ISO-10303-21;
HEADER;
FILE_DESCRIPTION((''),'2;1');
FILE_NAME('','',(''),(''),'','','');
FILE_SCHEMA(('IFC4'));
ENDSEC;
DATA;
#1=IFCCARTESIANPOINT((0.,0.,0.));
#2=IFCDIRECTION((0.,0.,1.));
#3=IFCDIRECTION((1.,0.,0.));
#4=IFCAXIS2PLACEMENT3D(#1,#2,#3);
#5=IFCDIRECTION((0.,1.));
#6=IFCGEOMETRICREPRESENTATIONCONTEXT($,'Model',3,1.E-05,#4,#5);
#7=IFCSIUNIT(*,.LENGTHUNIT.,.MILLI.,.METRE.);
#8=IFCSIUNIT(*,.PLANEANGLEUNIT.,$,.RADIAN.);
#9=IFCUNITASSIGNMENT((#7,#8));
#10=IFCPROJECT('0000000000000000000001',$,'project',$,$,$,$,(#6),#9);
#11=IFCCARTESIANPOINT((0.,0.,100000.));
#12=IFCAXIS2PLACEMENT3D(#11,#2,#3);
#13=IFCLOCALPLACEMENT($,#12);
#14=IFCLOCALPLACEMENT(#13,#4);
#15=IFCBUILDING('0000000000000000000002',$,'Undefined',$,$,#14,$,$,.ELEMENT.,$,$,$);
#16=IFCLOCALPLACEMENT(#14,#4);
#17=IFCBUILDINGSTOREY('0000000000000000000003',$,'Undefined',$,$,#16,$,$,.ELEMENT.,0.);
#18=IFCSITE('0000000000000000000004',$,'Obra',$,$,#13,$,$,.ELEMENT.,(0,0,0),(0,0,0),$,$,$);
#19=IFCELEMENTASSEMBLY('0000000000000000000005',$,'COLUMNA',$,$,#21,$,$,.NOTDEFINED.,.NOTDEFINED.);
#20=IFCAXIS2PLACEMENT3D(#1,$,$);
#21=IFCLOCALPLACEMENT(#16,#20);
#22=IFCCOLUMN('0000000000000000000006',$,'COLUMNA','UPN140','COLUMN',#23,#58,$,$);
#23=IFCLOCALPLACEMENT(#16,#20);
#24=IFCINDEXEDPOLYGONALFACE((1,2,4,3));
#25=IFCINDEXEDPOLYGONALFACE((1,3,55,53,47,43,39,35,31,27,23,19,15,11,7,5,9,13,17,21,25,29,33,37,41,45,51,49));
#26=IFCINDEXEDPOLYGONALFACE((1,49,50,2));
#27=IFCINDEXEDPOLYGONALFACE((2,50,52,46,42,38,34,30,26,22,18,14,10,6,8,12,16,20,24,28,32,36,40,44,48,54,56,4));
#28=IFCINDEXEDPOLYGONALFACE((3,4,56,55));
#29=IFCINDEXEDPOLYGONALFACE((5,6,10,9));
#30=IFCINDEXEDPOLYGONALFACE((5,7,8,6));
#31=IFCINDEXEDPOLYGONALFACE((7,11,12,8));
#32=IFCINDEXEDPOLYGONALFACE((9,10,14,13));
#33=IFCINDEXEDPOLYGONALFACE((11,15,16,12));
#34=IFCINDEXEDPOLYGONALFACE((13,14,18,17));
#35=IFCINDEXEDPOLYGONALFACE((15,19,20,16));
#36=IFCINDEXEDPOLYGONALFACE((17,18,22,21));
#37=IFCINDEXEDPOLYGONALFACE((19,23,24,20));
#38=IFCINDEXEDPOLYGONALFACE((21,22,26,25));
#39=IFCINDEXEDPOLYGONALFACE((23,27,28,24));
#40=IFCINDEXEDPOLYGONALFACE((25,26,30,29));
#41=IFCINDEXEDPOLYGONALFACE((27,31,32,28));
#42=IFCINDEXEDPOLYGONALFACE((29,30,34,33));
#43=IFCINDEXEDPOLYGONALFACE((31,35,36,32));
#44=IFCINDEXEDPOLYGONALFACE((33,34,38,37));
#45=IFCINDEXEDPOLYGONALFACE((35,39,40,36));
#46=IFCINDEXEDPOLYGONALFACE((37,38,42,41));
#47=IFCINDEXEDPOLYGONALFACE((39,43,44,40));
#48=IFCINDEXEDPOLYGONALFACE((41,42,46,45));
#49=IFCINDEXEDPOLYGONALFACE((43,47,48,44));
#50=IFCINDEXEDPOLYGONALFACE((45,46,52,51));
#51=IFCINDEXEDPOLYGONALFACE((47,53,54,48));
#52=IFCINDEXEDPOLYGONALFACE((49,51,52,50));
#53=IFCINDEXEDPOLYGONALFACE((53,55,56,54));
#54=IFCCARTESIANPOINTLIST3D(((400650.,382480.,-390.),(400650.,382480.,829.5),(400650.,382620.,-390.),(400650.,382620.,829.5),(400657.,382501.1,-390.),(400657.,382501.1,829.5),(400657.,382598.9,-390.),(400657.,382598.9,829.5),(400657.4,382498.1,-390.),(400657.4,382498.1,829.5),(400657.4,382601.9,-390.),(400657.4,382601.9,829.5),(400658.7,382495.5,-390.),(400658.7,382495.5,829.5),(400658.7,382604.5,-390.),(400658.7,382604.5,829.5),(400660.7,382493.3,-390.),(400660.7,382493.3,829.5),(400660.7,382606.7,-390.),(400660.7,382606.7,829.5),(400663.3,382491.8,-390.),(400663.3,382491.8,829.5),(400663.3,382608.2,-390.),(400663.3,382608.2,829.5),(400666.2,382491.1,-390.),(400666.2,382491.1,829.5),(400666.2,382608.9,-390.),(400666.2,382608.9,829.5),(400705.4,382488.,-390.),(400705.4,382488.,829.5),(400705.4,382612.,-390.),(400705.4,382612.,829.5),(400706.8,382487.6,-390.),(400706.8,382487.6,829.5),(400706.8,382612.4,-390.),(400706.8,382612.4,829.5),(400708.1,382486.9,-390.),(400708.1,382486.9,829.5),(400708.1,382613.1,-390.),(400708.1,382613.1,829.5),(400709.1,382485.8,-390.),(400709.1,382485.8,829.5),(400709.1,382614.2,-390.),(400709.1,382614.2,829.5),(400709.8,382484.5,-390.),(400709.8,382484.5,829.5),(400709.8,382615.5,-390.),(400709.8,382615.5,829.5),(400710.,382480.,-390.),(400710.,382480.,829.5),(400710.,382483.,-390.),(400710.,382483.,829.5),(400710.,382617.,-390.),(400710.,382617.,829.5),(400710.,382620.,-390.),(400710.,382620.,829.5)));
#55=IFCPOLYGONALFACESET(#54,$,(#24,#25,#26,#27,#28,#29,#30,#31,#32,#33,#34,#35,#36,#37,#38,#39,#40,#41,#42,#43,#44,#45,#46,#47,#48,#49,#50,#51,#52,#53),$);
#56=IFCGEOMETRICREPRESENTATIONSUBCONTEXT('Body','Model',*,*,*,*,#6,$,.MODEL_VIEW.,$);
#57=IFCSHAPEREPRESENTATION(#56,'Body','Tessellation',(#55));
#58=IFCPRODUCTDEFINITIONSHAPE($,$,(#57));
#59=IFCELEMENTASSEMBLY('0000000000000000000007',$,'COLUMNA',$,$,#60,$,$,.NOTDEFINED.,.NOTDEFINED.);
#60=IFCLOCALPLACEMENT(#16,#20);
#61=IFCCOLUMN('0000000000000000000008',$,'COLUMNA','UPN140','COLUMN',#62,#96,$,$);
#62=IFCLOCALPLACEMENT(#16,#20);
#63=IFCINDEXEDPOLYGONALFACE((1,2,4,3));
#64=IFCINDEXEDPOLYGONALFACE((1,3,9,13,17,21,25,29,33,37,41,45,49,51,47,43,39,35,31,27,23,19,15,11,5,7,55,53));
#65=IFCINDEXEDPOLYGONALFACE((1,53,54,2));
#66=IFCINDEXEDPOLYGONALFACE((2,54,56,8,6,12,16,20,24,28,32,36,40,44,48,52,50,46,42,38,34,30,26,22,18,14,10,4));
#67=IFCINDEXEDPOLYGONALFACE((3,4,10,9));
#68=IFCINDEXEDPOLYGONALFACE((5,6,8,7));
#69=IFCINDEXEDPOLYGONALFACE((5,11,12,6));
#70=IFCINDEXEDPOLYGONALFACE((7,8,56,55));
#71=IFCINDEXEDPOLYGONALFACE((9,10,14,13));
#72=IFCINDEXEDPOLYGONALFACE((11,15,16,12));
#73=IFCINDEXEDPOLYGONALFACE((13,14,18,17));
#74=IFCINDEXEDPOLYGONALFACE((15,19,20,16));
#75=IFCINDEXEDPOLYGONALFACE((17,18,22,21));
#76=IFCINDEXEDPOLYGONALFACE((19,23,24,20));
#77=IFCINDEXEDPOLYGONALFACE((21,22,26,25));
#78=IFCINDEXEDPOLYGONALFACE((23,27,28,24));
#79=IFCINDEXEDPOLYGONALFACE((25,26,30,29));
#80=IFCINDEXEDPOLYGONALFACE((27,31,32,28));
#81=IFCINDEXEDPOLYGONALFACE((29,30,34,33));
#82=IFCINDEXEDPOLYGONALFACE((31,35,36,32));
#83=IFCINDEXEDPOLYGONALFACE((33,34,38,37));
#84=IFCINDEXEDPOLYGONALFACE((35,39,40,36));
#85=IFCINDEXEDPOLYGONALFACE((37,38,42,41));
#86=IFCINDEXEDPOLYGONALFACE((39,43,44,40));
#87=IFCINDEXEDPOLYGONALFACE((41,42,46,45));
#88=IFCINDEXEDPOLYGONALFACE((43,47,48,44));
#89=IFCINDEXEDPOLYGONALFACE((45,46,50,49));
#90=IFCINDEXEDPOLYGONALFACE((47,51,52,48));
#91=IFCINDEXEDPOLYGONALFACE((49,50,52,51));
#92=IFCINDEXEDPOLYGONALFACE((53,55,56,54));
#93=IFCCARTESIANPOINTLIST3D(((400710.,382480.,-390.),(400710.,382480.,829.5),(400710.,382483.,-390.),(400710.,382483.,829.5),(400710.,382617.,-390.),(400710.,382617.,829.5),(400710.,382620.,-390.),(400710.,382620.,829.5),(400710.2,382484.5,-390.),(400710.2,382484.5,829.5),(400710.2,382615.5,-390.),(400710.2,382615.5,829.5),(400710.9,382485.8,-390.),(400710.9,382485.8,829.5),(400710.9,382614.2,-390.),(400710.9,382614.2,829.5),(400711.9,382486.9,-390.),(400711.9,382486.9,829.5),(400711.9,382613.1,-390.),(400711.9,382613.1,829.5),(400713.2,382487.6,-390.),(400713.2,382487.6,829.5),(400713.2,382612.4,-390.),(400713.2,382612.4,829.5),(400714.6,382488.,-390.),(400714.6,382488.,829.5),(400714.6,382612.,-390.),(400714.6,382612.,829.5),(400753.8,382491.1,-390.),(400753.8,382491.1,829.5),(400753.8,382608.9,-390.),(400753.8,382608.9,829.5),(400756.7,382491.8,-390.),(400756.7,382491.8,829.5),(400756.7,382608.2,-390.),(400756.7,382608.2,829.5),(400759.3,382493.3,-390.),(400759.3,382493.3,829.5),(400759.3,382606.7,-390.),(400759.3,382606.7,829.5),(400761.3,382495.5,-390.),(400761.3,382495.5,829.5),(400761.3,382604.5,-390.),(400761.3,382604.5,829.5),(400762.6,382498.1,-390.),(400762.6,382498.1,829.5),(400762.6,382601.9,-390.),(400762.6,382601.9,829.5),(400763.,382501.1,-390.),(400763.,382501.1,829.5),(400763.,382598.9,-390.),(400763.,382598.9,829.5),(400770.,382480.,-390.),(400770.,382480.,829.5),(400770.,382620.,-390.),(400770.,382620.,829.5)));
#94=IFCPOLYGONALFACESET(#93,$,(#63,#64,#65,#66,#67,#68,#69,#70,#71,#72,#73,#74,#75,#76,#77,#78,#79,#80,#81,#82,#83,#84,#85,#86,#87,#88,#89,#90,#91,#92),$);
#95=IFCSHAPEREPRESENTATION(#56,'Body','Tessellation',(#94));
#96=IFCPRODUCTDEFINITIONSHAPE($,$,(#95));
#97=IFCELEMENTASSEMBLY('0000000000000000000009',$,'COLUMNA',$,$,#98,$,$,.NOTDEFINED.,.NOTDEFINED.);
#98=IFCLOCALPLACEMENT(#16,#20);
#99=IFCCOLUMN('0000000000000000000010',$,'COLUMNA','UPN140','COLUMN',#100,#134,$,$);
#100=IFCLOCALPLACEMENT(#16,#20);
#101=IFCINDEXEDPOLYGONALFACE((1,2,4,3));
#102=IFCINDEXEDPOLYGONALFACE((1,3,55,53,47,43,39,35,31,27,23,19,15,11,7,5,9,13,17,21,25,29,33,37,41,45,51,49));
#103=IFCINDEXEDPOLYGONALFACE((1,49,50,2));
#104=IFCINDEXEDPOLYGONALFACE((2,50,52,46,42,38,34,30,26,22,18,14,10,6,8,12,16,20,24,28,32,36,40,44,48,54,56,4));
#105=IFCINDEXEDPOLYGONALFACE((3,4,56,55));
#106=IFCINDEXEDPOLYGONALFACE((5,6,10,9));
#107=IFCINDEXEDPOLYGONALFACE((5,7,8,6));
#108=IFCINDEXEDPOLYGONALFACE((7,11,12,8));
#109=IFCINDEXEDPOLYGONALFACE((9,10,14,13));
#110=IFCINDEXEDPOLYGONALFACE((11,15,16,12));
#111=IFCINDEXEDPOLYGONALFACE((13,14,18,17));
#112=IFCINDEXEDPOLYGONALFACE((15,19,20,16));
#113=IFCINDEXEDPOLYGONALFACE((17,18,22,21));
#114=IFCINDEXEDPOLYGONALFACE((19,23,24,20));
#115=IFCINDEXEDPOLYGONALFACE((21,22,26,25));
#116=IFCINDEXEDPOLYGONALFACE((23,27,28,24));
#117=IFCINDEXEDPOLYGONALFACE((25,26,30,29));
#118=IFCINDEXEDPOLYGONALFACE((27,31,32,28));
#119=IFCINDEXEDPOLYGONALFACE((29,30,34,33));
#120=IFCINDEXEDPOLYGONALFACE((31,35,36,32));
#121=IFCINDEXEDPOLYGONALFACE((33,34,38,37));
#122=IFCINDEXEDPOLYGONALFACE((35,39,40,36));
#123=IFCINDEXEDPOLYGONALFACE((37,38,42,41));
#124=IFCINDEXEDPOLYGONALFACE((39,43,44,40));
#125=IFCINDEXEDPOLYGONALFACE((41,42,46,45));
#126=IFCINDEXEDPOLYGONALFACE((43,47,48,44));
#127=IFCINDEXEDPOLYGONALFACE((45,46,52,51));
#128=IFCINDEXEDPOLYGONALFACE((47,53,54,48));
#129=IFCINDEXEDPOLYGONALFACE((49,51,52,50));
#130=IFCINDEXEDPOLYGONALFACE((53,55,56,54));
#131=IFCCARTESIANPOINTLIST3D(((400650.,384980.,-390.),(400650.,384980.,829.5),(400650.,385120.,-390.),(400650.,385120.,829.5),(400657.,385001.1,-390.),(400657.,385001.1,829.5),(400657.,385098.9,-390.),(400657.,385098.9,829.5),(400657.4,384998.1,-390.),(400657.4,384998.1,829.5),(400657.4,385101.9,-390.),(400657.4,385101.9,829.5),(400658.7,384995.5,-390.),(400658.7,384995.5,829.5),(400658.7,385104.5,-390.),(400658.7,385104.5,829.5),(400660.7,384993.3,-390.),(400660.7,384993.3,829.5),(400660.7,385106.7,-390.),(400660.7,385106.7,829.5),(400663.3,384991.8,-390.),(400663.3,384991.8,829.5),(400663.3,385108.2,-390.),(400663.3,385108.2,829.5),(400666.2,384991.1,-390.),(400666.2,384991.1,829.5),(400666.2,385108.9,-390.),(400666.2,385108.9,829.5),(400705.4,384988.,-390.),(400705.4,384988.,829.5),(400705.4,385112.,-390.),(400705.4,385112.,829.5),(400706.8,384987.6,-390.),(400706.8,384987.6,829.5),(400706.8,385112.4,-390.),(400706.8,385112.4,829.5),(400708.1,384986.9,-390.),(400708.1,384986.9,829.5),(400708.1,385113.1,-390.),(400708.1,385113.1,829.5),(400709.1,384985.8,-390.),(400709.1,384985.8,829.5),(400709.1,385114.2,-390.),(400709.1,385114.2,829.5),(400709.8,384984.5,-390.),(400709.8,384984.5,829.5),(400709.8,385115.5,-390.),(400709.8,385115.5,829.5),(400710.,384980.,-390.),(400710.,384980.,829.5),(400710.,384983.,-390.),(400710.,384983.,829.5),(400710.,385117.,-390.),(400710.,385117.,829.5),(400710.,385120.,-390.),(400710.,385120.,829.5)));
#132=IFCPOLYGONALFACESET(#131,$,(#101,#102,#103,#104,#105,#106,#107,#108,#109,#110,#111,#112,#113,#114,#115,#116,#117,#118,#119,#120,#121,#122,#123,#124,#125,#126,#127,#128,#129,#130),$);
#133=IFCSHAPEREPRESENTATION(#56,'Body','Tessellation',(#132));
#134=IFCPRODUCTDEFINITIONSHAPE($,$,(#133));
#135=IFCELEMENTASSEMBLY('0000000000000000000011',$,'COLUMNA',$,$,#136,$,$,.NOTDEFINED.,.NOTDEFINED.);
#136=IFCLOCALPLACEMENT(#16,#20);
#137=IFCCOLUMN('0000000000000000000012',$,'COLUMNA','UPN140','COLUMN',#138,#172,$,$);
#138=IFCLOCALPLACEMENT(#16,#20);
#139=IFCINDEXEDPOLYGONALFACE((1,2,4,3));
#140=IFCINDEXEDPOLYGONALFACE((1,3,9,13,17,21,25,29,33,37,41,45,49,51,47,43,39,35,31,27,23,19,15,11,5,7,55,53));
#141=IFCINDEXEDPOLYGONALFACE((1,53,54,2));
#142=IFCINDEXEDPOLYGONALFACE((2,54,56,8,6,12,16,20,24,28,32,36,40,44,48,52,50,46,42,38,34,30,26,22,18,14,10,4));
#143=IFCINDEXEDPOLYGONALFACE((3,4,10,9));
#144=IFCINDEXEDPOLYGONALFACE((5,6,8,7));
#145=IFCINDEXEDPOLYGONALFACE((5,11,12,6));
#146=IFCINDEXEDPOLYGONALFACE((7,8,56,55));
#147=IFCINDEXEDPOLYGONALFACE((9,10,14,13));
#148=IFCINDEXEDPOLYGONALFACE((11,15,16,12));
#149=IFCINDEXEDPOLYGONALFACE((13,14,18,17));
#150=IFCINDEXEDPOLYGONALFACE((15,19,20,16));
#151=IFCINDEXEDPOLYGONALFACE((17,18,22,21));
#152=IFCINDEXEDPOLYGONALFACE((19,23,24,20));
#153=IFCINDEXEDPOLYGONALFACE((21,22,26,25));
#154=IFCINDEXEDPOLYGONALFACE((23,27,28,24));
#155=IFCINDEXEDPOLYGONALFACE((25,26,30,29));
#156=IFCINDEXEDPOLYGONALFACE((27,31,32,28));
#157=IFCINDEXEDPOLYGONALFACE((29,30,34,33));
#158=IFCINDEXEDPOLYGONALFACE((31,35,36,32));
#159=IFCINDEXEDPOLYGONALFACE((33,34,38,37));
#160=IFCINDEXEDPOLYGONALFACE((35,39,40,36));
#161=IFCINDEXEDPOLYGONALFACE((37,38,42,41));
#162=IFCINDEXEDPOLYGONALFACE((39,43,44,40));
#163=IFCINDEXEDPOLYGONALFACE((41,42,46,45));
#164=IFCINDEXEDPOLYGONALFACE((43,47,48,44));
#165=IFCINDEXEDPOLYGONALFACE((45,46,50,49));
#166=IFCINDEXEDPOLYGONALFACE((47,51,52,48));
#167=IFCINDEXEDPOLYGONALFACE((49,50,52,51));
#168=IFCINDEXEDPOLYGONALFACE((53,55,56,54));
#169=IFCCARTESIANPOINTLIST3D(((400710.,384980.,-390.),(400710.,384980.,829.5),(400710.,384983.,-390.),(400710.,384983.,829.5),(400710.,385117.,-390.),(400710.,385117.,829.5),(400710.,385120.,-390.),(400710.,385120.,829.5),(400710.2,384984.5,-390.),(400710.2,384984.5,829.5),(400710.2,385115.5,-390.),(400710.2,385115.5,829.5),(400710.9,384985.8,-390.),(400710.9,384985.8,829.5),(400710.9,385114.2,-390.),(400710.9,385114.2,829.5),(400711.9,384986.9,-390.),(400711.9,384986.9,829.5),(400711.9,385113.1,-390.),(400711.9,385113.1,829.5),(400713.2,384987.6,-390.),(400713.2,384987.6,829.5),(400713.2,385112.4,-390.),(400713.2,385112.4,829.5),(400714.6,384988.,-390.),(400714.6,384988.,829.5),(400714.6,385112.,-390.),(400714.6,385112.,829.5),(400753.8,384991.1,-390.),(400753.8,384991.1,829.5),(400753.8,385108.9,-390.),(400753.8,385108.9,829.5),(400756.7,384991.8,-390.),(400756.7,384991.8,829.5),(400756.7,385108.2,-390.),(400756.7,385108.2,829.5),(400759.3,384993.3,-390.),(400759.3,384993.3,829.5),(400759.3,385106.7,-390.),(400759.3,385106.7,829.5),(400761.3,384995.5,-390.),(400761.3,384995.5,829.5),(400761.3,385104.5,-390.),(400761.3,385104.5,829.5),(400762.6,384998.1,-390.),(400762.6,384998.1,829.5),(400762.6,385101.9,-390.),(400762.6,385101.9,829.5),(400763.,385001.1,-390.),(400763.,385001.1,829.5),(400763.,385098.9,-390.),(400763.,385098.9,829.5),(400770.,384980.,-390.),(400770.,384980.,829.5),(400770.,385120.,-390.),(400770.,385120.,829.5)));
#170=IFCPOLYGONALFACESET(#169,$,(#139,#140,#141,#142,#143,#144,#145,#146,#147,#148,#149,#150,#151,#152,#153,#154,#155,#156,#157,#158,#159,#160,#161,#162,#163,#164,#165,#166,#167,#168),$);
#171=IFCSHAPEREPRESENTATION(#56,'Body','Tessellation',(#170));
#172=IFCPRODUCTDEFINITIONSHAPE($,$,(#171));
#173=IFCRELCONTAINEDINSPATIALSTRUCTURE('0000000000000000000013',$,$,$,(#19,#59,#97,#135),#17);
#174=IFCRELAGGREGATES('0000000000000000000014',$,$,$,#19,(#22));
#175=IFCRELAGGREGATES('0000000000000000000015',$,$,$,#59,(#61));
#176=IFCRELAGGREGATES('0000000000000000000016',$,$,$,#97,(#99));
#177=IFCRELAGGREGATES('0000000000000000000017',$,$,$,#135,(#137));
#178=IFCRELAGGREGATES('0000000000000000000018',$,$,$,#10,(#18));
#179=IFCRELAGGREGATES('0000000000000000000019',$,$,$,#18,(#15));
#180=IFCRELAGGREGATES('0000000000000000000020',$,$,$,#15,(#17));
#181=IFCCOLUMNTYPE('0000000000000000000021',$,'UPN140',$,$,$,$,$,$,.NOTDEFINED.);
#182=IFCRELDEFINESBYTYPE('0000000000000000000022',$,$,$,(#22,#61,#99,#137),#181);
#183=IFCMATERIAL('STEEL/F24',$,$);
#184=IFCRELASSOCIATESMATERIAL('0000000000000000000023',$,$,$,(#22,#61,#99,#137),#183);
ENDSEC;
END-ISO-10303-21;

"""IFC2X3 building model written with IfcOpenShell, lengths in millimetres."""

from ifc_helpers import new_model, si_unit, direction, frame, origin_with_axes, origin_2d_with_axis, place, context, subcontext, project, spatial, u_section, extrude, material, type_object, element, aggregate, save


model = new_model("IFC2X3")

# Units and contexts
model_context = context("Model", 3, precision=1e-05, world=origin_with_axes(), true_north=direction((0.0, 1.0)))
body_context = subcontext(model_context, "Body", "Model", "MODEL_VIEW")
ifc_project = project(units=[si_unit("LENGTHUNIT", "METRE", prefix="MILLI"), si_unit("PLANEANGLEUNIT", "RADIAN")], contexts=[model_context])

# Site, building, storey
site_placement = place(None, frame((0.0, 0.0, 100000.0), z_axis=(0.0, 0.0, 1.0), x_axis=(1.0, 0.0, 0.0)))
site = spatial("IfcSite", under=ifc_project, at=site_placement, Name="Obra", CompositionType="ELEMENT", RefLatitude=(0, 0, 0), RefLongitude=(0, 0, 0))
building_placement = place(site_placement, origin_with_axes())
building = spatial("IfcBuilding", under=site, at=building_placement, Name="Undefined", CompositionType="ELEMENT")
storey_placement = place(building_placement, origin_with_axes())
storey = spatial("IfcBuildingStorey", under=building, at=storey_placement, Name="Undefined", CompositionType="ELEMENT", Elevation=0.0)

# Element assemblies, columns
ifc_material_1 = material(Name="STEEL/F24")
column_type_1 = type_object("IfcColumnType", Name="UPN140", PredefinedType="NOTDEFINED")
assembly_1_placement = place(storey_placement, origin_with_axes())
assembly_1 = element("IfcElementAssembly", 1, at=assembly_1_placement, inside=storey, Name="COLUMNA", AssemblyPlace="NOTDEFINED", PredefinedType="NOTDEFINED")
column_1_placement = place(assembly_1_placement, frame((400680.0, 382550.0, -390.0), z_axis=(0.0, 0.0, 1.0), x_axis=(0.0, -1.0, 0.0)))
column_1 = element("IfcColumn", 2, at=column_1_placement, type_object=column_type_1, material=ifc_material_1, Name="COLUMNA", Description="UPN140", ObjectType="COLUMN", context=body_context, shape_type="SweptSolid", body=[
    extrude(u_section(Depth=140.0, FlangeWidth=60.0, WebThickness=7.0, FlangeThickness=10.0, FilletRadius=10.0, EdgeRadius=5.0, FlangeSlope=0.07983, at=origin_2d_with_axis()), frame((0.0, 0.0, 1219.5), z_axis=(0.0, 0.0, -1.0), x_axis=(0.0, 1.0, 0.0)), (0.0, 0.0, 1.0), 1219.5),
])
aggregate(assembly_1, [column_1])
assembly_2_placement = place(storey_placement, origin_with_axes())
assembly_2 = element("IfcElementAssembly", 3, at=assembly_2_placement, inside=storey, Name="COLUMNA", AssemblyPlace="NOTDEFINED", PredefinedType="NOTDEFINED")
column_2_placement = place(assembly_2_placement, frame((400740.0, 382550.0, -390.0), z_axis=(0.0, 0.0, 1.0), x_axis=(0.0, 1.0, 0.0)))
column_2 = element("IfcColumn", 4, at=column_2_placement, type_object=column_type_1, material=ifc_material_1, Name="COLUMNA", Description="UPN140", ObjectType="COLUMN", context=body_context, shape_type="SweptSolid", body=[
    extrude(u_section(Depth=140.0, FlangeWidth=60.0, WebThickness=7.0, FlangeThickness=10.0, FilletRadius=10.0, EdgeRadius=5.0, FlangeSlope=0.07983, at=origin_2d_with_axis()), frame((0.0, 0.0, 1219.5), z_axis=(0.0, 0.0, -1.0), x_axis=(0.0, 1.0, 0.0)), (0.0, 0.0, 1.0), 1219.5),
])
aggregate(assembly_2, [column_2])
assembly_3_placement = place(storey_placement, origin_with_axes())
assembly_3 = element("IfcElementAssembly", 5, at=assembly_3_placement, inside=storey, Name="COLUMNA", AssemblyPlace="NOTDEFINED", PredefinedType="NOTDEFINED")
column_3_placement = place(assembly_3_placement, frame((400680.0, 385050.0, -390.0), z_axis=(0.0, 0.0, 1.0), x_axis=(0.0, -1.0, 0.0)))
column_3 = element("IfcColumn", 6, at=column_3_placement, type_object=column_type_1, material=ifc_material_1, Name="COLUMNA", Description="UPN140", ObjectType="COLUMN", context=body_context, shape_type="SweptSolid", body=[
    extrude(u_section(Depth=140.0, FlangeWidth=60.0, WebThickness=7.0, FlangeThickness=10.0, FilletRadius=10.0, EdgeRadius=5.0, FlangeSlope=0.07983, at=origin_2d_with_axis()), frame((0.0, 0.0, 1219.5), z_axis=(0.0, 0.0, -1.0), x_axis=(0.0, 1.0, 0.0)), (0.0, 0.0, 1.0), 1219.5),
])
aggregate(assembly_3, [column_3])
assembly_4_placement = place(storey_placement, origin_with_axes())
assembly_4 = element("IfcElementAssembly", 7, at=assembly_4_placement, inside=storey, Name="COLUMNA", AssemblyPlace="NOTDEFINED", PredefinedType="NOTDEFINED")
column_4_placement = place(assembly_4_placement, frame((400740.0, 385050.0, -390.0), z_axis=(0.0, 0.0, 1.0), x_axis=(0.0, 1.0, 0.0)))
column_4 = element("IfcColumn", 8, at=column_4_placement, type_object=column_type_1, material=ifc_material_1, Name="COLUMNA", Description="UPN140", ObjectType="COLUMN", context=body_context, shape_type="SweptSolid", body=[
    extrude(u_section(Depth=140.0, FlangeWidth=60.0, WebThickness=7.0, FlangeThickness=10.0, FilletRadius=10.0, EdgeRadius=5.0, FlangeSlope=0.07983, at=origin_2d_with_axis()), frame((0.0, 0.0, 1219.5), z_axis=(0.0, 0.0, -1.0), x_axis=(0.0, 1.0, 0.0)), (0.0, 0.0, 1.0), 1219.5),
])
aggregate(assembly_4, [column_4])

save(model, "model.ifc")
